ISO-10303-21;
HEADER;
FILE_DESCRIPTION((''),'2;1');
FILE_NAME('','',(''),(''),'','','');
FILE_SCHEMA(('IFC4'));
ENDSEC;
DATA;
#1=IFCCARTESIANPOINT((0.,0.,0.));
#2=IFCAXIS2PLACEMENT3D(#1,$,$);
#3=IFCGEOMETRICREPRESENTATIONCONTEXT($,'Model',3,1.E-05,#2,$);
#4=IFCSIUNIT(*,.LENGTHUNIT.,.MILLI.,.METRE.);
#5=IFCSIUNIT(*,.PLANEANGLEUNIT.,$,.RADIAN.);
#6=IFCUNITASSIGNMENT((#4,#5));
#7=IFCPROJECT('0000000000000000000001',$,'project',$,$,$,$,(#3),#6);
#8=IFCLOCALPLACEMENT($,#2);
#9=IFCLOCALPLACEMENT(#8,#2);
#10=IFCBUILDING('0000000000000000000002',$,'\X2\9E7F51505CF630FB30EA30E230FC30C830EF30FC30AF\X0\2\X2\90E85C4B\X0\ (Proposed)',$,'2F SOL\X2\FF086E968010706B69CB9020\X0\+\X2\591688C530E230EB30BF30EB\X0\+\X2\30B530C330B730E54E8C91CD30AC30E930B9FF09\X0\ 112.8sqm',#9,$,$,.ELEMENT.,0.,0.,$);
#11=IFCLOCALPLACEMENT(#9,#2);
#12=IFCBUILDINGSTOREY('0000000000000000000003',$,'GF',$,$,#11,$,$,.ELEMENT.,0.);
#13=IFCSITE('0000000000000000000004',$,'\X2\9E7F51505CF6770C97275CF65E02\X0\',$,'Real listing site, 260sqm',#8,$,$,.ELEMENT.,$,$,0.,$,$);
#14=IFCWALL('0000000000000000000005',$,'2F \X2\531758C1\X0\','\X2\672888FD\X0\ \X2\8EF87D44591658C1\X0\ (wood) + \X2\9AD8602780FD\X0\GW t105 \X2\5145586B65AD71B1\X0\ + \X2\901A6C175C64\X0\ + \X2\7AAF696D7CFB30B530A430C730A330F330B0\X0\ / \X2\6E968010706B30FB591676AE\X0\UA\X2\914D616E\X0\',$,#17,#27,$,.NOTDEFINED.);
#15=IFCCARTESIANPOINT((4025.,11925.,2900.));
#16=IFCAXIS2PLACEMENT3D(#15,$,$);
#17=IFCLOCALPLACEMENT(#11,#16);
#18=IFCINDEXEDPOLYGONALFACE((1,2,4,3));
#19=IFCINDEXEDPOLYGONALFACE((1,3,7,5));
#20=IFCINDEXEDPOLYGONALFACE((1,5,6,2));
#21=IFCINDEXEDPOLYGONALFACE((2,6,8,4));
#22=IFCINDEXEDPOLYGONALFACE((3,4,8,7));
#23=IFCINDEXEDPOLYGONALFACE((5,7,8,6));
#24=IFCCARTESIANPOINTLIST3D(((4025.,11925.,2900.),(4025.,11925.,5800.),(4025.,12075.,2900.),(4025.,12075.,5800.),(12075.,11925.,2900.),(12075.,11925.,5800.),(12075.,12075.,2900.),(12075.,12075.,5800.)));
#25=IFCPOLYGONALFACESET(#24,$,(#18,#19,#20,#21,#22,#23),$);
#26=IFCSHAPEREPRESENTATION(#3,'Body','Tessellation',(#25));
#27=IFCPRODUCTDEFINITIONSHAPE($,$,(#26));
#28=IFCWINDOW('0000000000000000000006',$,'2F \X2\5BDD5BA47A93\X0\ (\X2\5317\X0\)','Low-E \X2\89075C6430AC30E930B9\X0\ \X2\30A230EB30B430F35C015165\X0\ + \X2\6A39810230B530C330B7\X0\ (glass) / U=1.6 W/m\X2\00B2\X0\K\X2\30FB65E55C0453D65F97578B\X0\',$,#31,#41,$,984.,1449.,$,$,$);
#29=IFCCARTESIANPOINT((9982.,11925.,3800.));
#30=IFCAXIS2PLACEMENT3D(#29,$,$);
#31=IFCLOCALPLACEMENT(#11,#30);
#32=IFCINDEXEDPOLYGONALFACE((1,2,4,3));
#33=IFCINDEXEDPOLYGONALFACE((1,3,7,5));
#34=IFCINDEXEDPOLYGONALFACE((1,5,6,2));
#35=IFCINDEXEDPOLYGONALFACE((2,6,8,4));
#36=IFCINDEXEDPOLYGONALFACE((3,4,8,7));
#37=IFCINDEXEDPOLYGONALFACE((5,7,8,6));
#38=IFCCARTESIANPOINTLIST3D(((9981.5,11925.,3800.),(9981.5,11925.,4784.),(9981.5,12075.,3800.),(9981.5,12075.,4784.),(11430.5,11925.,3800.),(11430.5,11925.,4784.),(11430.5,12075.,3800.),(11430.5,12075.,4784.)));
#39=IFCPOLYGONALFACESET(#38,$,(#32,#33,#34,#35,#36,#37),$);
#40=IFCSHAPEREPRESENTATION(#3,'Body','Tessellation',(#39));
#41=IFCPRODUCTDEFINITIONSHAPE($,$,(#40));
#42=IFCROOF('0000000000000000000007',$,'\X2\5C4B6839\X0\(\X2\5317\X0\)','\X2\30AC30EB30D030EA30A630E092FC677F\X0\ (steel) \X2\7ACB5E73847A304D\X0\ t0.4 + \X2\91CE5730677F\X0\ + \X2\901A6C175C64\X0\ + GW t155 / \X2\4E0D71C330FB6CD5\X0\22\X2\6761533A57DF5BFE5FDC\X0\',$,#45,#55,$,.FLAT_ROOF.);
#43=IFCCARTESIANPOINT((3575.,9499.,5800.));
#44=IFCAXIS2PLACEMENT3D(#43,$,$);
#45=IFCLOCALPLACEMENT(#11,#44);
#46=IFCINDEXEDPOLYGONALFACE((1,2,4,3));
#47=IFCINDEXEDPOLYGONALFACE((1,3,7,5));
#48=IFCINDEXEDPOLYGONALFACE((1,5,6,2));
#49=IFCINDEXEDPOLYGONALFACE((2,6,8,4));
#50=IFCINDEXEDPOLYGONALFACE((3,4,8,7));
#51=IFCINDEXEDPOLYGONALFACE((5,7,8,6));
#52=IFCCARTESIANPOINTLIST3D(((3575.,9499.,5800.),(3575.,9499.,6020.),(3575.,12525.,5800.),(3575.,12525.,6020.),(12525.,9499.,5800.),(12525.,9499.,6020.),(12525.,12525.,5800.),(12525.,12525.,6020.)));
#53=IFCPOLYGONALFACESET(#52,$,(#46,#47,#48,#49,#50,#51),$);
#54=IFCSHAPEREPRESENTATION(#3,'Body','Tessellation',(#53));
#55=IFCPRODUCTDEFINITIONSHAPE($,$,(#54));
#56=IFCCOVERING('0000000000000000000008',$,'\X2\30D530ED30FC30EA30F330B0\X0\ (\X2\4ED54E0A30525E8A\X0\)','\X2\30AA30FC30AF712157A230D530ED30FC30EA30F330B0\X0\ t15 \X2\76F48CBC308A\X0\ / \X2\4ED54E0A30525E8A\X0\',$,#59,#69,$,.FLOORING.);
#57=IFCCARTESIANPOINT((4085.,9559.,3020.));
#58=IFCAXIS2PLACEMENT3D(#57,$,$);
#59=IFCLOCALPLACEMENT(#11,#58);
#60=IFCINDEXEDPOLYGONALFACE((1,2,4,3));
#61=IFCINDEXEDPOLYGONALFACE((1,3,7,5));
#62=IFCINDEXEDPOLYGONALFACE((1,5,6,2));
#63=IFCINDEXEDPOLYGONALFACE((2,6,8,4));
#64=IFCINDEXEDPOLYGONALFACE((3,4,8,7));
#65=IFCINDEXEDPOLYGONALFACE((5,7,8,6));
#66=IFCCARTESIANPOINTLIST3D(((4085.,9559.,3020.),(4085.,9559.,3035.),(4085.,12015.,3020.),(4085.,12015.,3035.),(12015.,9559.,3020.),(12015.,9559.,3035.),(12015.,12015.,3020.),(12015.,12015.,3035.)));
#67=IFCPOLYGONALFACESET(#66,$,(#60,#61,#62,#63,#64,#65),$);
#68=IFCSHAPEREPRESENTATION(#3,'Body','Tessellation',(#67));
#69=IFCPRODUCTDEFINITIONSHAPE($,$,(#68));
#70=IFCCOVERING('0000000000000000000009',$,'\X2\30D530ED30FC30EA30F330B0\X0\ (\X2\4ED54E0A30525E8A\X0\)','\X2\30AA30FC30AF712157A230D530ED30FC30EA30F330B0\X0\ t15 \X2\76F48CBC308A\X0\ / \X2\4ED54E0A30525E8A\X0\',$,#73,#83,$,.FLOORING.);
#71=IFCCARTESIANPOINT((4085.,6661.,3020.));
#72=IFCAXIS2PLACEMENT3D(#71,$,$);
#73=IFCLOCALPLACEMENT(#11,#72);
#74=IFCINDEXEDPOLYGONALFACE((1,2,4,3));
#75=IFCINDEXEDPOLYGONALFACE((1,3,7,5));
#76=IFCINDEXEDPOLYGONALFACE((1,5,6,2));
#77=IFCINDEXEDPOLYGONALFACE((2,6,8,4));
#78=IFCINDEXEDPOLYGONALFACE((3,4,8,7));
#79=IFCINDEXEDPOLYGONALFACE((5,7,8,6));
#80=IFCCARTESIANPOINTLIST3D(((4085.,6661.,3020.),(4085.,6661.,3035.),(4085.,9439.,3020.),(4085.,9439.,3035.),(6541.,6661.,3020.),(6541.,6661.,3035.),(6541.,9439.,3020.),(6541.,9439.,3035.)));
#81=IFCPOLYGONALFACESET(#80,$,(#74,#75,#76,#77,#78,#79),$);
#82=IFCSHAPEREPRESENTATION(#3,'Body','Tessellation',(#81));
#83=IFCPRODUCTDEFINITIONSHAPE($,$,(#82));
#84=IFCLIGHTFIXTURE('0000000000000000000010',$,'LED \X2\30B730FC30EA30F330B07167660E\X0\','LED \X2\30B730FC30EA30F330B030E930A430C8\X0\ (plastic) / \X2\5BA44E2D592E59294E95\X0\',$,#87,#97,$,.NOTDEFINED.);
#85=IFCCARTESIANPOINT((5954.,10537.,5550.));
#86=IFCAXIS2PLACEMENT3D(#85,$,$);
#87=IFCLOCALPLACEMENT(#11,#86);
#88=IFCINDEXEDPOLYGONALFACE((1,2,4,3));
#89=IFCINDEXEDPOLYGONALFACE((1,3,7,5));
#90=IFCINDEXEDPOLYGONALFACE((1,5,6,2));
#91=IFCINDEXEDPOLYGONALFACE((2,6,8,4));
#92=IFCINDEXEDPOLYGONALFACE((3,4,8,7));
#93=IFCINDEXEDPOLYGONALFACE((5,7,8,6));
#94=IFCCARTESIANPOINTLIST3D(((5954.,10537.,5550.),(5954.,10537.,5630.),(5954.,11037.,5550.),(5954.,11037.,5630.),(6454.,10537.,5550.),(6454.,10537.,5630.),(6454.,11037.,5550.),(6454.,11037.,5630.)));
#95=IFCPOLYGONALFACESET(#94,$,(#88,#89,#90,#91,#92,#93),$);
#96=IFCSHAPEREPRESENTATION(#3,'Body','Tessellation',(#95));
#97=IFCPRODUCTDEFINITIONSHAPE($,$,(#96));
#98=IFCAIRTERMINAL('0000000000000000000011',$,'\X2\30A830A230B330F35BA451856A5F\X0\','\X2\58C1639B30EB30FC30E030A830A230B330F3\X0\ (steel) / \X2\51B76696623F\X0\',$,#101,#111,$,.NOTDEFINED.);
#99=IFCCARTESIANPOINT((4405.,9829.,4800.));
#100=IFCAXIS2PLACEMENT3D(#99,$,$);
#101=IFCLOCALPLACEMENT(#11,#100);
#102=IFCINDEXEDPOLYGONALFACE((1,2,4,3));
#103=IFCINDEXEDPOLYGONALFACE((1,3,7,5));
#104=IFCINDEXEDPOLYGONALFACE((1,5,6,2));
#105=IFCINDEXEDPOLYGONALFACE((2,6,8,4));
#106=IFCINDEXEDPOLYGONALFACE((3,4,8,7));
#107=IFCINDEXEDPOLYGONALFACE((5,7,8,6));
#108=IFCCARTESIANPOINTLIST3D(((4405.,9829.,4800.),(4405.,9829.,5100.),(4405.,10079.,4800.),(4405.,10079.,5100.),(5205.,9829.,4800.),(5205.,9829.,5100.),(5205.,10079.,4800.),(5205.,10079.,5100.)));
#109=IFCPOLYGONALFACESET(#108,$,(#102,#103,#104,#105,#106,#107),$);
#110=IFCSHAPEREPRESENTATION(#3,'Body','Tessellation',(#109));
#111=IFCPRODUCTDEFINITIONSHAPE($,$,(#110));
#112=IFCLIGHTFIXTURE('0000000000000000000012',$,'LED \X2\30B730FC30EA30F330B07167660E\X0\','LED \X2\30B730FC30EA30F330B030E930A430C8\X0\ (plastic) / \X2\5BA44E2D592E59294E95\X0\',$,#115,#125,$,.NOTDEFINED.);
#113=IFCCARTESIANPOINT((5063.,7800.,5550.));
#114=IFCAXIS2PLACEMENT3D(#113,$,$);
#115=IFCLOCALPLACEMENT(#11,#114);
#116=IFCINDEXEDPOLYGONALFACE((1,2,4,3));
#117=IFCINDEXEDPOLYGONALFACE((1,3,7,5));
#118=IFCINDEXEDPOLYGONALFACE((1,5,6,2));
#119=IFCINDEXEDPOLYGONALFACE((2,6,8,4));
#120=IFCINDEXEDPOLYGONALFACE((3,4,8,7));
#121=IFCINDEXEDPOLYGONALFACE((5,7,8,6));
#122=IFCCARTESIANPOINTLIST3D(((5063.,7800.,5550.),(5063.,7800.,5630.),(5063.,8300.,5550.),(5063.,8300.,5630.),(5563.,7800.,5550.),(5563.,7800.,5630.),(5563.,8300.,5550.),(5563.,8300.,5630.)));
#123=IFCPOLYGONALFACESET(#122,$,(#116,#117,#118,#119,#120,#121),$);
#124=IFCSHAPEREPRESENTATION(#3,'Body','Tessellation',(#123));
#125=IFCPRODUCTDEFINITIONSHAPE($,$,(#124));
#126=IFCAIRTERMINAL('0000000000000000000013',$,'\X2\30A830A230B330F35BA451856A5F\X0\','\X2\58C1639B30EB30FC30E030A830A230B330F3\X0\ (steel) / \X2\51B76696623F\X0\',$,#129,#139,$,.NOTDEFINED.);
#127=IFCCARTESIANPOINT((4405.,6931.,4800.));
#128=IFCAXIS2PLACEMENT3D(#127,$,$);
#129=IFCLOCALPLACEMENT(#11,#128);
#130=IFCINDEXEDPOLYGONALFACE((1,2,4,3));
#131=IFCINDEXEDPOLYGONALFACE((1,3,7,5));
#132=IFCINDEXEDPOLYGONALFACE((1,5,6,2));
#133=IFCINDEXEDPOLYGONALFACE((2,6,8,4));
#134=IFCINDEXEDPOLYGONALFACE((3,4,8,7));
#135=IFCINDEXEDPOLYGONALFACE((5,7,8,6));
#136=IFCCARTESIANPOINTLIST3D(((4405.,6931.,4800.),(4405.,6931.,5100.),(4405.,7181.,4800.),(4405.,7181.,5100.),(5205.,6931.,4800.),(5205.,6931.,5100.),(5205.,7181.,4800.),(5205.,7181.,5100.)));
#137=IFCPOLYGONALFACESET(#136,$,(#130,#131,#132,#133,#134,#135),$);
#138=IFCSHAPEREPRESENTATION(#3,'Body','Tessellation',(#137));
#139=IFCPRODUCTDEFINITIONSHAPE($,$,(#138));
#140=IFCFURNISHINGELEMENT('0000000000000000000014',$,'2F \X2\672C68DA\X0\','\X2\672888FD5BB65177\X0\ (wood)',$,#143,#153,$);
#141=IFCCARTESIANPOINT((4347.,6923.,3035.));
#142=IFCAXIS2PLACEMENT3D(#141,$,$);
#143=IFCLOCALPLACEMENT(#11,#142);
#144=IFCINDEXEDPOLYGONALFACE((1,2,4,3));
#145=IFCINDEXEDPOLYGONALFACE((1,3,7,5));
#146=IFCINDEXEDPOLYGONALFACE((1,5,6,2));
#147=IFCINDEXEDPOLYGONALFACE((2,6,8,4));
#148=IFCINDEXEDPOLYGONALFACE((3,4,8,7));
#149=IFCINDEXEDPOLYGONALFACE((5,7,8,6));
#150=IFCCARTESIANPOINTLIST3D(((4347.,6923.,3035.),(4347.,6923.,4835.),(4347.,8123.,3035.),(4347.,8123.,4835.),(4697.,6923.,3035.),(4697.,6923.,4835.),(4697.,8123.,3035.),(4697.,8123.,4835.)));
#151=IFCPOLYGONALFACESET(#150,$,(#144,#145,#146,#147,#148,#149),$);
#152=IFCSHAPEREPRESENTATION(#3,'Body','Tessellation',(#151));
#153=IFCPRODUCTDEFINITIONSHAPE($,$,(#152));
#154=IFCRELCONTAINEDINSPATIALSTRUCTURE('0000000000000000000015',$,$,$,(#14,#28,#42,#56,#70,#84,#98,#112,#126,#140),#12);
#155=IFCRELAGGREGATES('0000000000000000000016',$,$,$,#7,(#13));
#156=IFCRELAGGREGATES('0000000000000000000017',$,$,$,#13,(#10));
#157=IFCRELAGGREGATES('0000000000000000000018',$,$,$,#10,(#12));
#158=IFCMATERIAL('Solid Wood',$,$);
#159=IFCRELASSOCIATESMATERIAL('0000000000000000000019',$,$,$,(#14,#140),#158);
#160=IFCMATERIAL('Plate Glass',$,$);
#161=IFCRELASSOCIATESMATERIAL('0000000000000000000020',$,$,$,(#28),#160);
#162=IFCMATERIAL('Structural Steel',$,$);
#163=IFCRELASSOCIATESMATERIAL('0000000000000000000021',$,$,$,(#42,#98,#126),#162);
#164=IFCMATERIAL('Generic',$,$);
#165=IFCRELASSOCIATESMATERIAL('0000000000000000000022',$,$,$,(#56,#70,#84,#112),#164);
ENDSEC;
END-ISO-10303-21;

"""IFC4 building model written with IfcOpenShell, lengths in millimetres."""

from ifc_helpers import new_model, si_unit, frame, frame_2d, origin, place, context, project, spatial, rectangle, extrude, material, element, fill, save


model = new_model("IFC4")

# Units and contexts
model_context = context("Model", 3, precision=1e-05, world=origin())
ifc_project = project(units=[si_unit("LENGTHUNIT", "METRE", prefix="MILLI"), si_unit("PLANEANGLEUNIT", "RADIAN")], contexts=[model_context])

# Site, building, storey
site_placement = place(None, origin())
site = spatial("IfcSite", under=ifc_project, at=site_placement, Name="鹿児島県霧島市", ObjectType="Real listing site, 260sqm", CompositionType="ELEMENT", RefElevation=0.0)
building_placement = place(site_placement, origin())
building = spatial("IfcBuilding", under=site, at=building_placement, Name="鹿児島・リモートワーク2部屋 (Proposed)", ObjectType="2F SOL（準耐火構造+外装モルタル+サッシュ二重ガラス） 112.8sqm", CompositionType="ELEMENT", ElevationOfRefHeight=0.0, ElevationOfTerrain=0.0)
storey_placement = place(building_placement, origin())
storey = spatial("IfcBuildingStorey", under=building, at=storey_placement, Name="GF", CompositionType="ELEMENT", Elevation=0.0)

# Shared definitions
ifc_material_1 = material(Name="Solid Wood")

# Wall, opening, window
wall_placement = place(storey_placement, frame((4025.0, 11925.0, 2900.0)))
wall = element("IfcWall", 1, at=wall_placement, inside=storey, material=ifc_material_1, Name="2F 北壁", Description="木製 軸組外壁 (wood) + 高性能GW t105 充填断熱 + 通気層 + 窯業系サイディング / 準耐火・外皮UA配慮", PredefinedType="NOTDEFINED", context=model_context, shape_type="SweptSolid", body=[
    extrude(rectangle(XDim=8050.0, YDim=150.0, at=frame_2d((4025.0, 75.0))), frame((4025.0, 11925.0, 2900.0)), (0.0, 0.0, 1.0), 2900.0),
])
opening_placement = place(storey_placement, frame((9982.0, 11925.0, 3800.0)))
opening = element("IfcOpeningElement", 2, at=opening_placement, cuts=wall, PredefinedType="NOTDEFINED", context=model_context, shape_type="SweptSolid", body=[
    extrude(rectangle(XDim=1449.0, YDim=150.0, at=frame_2d((724.0, 75.0))), frame((9982.0, 11925.0, 3800.0)), (0.0, 0.0, 1.0), 984.0),
])
ifc_material_2 = material(Name="Plate Glass")
window_placement = place(storey_placement, frame((9982.0, 11925.0, 3800.0)))
window = element("IfcWindow", 3, at=window_placement, inside=storey, material=ifc_material_2, Name="2F 寝室窓 (北)", Description="Low-E 複層ガラス アルゴン封入 + 樹脂サッシ (glass) / U=1.6 W/m²K・日射取得型", OverallHeight=984.0, OverallWidth=1449.0, context=model_context, shape_type="SweptSolid", body=[
    extrude(rectangle(XDim=1449.0, YDim=150.0, at=frame_2d((724.0, 75.0))), frame((9982.0, 11925.0, 3800.0)), (0.0, 0.0, 1.0), 984.0),
])
fill(opening, window)

# Roof
ifc_material_3 = material(Name="Structural Steel")
for number, where, name in (
    (4, (3575.0, 9499.0, 5800.0), "屋根(北)"),
):
    element("IfcRoof", number, at=place(storey_placement, frame(where)), inside=storey, material=ifc_material_3, Name=name, Description="ガルバリウム鋼板 (steel) 立平葺き t0.4 + 野地板 + 通気層 + GW t155 / 不燃・法22条区域対応", PredefinedType="FLAT_ROOF", context=model_context, shape_type="SweptSolid", body=[
        extrude(rectangle(XDim=8950.0, YDim=3026.0, at=frame_2d((4475.0, 1513.0))), frame((3575.0, 9499.0, 5800.0)), (0.0, 0.0, 1.0), 220.0),
    ])

# Coverings
ifc_material_4 = material(Name="Generic")
covering_1_placement = place(storey_placement, frame((4085.0, 9559.0, 3020.0)))
element("IfcCovering", 5, at=covering_1_placement, inside=storey, material=ifc_material_4, Name="フローリング (仕上げ床)", Description="オーク無垢フローリング t15 直貼り / 仕上げ床", PredefinedType="FLOORING", context=model_context, shape_type="SweptSolid", body=[
    extrude(rectangle(XDim=7930.0, YDim=2456.0, at=frame_2d((3965.0, 1228.0))), frame((4085.0, 9559.0, 3020.0)), (0.0, 0.0, 1.0), 15.0),
])
covering_2_placement = place(storey_placement, frame((4085.0, 6661.0, 3020.0)))
element("IfcCovering", 6, at=covering_2_placement, inside=storey, material=ifc_material_4, Name="フローリング (仕上げ床)", Description="オーク無垢フローリング t15 直貼り / 仕上げ床", PredefinedType="FLOORING", context=model_context, shape_type="SweptSolid", body=[
    extrude(rectangle(XDim=2456.0, YDim=2778.0, at=frame_2d((1228.0, 1389.0))), frame((4085.0, 6661.0, 3020.0)), (0.0, 0.0, 1.0), 15.0),
])

# Light fixture
light_fixture_1_placement = place(storey_placement, frame((5954.0, 10537.0, 5550.0)))
element("IfcLightFixture", 7, at=light_fixture_1_placement, inside=storey, material=ifc_material_4, Name="LED シーリング照明", Description="LED シーリングライト (plastic) / 室中央天井", PredefinedType="NOTDEFINED", context=model_context, shape_type="SweptSolid", body=[
    extrude(rectangle(XDim=500.0, YDim=500.0, at=frame_2d((250.0, 250.0))), frame((5954.0, 10537.0, 5550.0)), (0.0, 0.0, 1.0), 80.0),
])

# Air terminal
air_terminal_1_placement = place(storey_placement, frame((4405.0, 9829.0, 4800.0)))
element("IfcAirTerminal", 8, at=air_terminal_1_placement, inside=storey, material=ifc_material_3, Name="エアコン室内機", Description="壁掛ルームエアコン (steel) / 冷暖房", PredefinedType="NOTDEFINED", context=model_context, shape_type="SweptSolid", body=[
    extrude(rectangle(XDim=800.0, YDim=250.0, at=frame_2d((400.0, 125.0))), frame((4405.0, 9829.0, 4800.0)), (0.0, 0.0, 1.0), 300.0),
])

# Light fixture
light_fixture_2_placement = place(storey_placement, frame((5063.0, 7800.0, 5550.0)))
element("IfcLightFixture", 9, at=light_fixture_2_placement, inside=storey, material=ifc_material_4, Name="LED シーリング照明", Description="LED シーリングライト (plastic) / 室中央天井", PredefinedType="NOTDEFINED", context=model_context, shape_type="SweptSolid", body=[
    extrude(rectangle(XDim=500.0, YDim=500.0, at=frame_2d((250.0, 250.0))), frame((5063.0, 7800.0, 5550.0)), (0.0, 0.0, 1.0), 80.0),
])

# Air terminal
air_terminal_2_placement = place(storey_placement, frame((4405.0, 6931.0, 4800.0)))
element("IfcAirTerminal", 10, at=air_terminal_2_placement, inside=storey, material=ifc_material_3, Name="エアコン室内機", Description="壁掛ルームエアコン (steel) / 冷暖房", PredefinedType="NOTDEFINED", context=model_context, shape_type="SweptSolid", body=[
    extrude(rectangle(XDim=800.0, YDim=250.0, at=frame_2d((400.0, 125.0))), frame((4405.0, 6931.0, 4800.0)), (0.0, 0.0, 1.0), 300.0),
])

# Furnishing element
furnishing_placement = place(storey_placement, frame((4347.0, 6923.0, 3035.0)))
element("IfcFurnishingElement", 11, at=furnishing_placement, inside=storey, material=ifc_material_1, Name="2F 本棚", Description="木製家具 (wood)", context=model_context, shape_type="SweptSolid", body=[
    extrude(rectangle(XDim=350.0, YDim=1200.0, at=frame_2d((175.0, 600.0))), frame((4347.0, 6923.0, 3035.0)), (0.0, 0.0, 1.0), 1800.0),
])

save(model, "model.ifc")
